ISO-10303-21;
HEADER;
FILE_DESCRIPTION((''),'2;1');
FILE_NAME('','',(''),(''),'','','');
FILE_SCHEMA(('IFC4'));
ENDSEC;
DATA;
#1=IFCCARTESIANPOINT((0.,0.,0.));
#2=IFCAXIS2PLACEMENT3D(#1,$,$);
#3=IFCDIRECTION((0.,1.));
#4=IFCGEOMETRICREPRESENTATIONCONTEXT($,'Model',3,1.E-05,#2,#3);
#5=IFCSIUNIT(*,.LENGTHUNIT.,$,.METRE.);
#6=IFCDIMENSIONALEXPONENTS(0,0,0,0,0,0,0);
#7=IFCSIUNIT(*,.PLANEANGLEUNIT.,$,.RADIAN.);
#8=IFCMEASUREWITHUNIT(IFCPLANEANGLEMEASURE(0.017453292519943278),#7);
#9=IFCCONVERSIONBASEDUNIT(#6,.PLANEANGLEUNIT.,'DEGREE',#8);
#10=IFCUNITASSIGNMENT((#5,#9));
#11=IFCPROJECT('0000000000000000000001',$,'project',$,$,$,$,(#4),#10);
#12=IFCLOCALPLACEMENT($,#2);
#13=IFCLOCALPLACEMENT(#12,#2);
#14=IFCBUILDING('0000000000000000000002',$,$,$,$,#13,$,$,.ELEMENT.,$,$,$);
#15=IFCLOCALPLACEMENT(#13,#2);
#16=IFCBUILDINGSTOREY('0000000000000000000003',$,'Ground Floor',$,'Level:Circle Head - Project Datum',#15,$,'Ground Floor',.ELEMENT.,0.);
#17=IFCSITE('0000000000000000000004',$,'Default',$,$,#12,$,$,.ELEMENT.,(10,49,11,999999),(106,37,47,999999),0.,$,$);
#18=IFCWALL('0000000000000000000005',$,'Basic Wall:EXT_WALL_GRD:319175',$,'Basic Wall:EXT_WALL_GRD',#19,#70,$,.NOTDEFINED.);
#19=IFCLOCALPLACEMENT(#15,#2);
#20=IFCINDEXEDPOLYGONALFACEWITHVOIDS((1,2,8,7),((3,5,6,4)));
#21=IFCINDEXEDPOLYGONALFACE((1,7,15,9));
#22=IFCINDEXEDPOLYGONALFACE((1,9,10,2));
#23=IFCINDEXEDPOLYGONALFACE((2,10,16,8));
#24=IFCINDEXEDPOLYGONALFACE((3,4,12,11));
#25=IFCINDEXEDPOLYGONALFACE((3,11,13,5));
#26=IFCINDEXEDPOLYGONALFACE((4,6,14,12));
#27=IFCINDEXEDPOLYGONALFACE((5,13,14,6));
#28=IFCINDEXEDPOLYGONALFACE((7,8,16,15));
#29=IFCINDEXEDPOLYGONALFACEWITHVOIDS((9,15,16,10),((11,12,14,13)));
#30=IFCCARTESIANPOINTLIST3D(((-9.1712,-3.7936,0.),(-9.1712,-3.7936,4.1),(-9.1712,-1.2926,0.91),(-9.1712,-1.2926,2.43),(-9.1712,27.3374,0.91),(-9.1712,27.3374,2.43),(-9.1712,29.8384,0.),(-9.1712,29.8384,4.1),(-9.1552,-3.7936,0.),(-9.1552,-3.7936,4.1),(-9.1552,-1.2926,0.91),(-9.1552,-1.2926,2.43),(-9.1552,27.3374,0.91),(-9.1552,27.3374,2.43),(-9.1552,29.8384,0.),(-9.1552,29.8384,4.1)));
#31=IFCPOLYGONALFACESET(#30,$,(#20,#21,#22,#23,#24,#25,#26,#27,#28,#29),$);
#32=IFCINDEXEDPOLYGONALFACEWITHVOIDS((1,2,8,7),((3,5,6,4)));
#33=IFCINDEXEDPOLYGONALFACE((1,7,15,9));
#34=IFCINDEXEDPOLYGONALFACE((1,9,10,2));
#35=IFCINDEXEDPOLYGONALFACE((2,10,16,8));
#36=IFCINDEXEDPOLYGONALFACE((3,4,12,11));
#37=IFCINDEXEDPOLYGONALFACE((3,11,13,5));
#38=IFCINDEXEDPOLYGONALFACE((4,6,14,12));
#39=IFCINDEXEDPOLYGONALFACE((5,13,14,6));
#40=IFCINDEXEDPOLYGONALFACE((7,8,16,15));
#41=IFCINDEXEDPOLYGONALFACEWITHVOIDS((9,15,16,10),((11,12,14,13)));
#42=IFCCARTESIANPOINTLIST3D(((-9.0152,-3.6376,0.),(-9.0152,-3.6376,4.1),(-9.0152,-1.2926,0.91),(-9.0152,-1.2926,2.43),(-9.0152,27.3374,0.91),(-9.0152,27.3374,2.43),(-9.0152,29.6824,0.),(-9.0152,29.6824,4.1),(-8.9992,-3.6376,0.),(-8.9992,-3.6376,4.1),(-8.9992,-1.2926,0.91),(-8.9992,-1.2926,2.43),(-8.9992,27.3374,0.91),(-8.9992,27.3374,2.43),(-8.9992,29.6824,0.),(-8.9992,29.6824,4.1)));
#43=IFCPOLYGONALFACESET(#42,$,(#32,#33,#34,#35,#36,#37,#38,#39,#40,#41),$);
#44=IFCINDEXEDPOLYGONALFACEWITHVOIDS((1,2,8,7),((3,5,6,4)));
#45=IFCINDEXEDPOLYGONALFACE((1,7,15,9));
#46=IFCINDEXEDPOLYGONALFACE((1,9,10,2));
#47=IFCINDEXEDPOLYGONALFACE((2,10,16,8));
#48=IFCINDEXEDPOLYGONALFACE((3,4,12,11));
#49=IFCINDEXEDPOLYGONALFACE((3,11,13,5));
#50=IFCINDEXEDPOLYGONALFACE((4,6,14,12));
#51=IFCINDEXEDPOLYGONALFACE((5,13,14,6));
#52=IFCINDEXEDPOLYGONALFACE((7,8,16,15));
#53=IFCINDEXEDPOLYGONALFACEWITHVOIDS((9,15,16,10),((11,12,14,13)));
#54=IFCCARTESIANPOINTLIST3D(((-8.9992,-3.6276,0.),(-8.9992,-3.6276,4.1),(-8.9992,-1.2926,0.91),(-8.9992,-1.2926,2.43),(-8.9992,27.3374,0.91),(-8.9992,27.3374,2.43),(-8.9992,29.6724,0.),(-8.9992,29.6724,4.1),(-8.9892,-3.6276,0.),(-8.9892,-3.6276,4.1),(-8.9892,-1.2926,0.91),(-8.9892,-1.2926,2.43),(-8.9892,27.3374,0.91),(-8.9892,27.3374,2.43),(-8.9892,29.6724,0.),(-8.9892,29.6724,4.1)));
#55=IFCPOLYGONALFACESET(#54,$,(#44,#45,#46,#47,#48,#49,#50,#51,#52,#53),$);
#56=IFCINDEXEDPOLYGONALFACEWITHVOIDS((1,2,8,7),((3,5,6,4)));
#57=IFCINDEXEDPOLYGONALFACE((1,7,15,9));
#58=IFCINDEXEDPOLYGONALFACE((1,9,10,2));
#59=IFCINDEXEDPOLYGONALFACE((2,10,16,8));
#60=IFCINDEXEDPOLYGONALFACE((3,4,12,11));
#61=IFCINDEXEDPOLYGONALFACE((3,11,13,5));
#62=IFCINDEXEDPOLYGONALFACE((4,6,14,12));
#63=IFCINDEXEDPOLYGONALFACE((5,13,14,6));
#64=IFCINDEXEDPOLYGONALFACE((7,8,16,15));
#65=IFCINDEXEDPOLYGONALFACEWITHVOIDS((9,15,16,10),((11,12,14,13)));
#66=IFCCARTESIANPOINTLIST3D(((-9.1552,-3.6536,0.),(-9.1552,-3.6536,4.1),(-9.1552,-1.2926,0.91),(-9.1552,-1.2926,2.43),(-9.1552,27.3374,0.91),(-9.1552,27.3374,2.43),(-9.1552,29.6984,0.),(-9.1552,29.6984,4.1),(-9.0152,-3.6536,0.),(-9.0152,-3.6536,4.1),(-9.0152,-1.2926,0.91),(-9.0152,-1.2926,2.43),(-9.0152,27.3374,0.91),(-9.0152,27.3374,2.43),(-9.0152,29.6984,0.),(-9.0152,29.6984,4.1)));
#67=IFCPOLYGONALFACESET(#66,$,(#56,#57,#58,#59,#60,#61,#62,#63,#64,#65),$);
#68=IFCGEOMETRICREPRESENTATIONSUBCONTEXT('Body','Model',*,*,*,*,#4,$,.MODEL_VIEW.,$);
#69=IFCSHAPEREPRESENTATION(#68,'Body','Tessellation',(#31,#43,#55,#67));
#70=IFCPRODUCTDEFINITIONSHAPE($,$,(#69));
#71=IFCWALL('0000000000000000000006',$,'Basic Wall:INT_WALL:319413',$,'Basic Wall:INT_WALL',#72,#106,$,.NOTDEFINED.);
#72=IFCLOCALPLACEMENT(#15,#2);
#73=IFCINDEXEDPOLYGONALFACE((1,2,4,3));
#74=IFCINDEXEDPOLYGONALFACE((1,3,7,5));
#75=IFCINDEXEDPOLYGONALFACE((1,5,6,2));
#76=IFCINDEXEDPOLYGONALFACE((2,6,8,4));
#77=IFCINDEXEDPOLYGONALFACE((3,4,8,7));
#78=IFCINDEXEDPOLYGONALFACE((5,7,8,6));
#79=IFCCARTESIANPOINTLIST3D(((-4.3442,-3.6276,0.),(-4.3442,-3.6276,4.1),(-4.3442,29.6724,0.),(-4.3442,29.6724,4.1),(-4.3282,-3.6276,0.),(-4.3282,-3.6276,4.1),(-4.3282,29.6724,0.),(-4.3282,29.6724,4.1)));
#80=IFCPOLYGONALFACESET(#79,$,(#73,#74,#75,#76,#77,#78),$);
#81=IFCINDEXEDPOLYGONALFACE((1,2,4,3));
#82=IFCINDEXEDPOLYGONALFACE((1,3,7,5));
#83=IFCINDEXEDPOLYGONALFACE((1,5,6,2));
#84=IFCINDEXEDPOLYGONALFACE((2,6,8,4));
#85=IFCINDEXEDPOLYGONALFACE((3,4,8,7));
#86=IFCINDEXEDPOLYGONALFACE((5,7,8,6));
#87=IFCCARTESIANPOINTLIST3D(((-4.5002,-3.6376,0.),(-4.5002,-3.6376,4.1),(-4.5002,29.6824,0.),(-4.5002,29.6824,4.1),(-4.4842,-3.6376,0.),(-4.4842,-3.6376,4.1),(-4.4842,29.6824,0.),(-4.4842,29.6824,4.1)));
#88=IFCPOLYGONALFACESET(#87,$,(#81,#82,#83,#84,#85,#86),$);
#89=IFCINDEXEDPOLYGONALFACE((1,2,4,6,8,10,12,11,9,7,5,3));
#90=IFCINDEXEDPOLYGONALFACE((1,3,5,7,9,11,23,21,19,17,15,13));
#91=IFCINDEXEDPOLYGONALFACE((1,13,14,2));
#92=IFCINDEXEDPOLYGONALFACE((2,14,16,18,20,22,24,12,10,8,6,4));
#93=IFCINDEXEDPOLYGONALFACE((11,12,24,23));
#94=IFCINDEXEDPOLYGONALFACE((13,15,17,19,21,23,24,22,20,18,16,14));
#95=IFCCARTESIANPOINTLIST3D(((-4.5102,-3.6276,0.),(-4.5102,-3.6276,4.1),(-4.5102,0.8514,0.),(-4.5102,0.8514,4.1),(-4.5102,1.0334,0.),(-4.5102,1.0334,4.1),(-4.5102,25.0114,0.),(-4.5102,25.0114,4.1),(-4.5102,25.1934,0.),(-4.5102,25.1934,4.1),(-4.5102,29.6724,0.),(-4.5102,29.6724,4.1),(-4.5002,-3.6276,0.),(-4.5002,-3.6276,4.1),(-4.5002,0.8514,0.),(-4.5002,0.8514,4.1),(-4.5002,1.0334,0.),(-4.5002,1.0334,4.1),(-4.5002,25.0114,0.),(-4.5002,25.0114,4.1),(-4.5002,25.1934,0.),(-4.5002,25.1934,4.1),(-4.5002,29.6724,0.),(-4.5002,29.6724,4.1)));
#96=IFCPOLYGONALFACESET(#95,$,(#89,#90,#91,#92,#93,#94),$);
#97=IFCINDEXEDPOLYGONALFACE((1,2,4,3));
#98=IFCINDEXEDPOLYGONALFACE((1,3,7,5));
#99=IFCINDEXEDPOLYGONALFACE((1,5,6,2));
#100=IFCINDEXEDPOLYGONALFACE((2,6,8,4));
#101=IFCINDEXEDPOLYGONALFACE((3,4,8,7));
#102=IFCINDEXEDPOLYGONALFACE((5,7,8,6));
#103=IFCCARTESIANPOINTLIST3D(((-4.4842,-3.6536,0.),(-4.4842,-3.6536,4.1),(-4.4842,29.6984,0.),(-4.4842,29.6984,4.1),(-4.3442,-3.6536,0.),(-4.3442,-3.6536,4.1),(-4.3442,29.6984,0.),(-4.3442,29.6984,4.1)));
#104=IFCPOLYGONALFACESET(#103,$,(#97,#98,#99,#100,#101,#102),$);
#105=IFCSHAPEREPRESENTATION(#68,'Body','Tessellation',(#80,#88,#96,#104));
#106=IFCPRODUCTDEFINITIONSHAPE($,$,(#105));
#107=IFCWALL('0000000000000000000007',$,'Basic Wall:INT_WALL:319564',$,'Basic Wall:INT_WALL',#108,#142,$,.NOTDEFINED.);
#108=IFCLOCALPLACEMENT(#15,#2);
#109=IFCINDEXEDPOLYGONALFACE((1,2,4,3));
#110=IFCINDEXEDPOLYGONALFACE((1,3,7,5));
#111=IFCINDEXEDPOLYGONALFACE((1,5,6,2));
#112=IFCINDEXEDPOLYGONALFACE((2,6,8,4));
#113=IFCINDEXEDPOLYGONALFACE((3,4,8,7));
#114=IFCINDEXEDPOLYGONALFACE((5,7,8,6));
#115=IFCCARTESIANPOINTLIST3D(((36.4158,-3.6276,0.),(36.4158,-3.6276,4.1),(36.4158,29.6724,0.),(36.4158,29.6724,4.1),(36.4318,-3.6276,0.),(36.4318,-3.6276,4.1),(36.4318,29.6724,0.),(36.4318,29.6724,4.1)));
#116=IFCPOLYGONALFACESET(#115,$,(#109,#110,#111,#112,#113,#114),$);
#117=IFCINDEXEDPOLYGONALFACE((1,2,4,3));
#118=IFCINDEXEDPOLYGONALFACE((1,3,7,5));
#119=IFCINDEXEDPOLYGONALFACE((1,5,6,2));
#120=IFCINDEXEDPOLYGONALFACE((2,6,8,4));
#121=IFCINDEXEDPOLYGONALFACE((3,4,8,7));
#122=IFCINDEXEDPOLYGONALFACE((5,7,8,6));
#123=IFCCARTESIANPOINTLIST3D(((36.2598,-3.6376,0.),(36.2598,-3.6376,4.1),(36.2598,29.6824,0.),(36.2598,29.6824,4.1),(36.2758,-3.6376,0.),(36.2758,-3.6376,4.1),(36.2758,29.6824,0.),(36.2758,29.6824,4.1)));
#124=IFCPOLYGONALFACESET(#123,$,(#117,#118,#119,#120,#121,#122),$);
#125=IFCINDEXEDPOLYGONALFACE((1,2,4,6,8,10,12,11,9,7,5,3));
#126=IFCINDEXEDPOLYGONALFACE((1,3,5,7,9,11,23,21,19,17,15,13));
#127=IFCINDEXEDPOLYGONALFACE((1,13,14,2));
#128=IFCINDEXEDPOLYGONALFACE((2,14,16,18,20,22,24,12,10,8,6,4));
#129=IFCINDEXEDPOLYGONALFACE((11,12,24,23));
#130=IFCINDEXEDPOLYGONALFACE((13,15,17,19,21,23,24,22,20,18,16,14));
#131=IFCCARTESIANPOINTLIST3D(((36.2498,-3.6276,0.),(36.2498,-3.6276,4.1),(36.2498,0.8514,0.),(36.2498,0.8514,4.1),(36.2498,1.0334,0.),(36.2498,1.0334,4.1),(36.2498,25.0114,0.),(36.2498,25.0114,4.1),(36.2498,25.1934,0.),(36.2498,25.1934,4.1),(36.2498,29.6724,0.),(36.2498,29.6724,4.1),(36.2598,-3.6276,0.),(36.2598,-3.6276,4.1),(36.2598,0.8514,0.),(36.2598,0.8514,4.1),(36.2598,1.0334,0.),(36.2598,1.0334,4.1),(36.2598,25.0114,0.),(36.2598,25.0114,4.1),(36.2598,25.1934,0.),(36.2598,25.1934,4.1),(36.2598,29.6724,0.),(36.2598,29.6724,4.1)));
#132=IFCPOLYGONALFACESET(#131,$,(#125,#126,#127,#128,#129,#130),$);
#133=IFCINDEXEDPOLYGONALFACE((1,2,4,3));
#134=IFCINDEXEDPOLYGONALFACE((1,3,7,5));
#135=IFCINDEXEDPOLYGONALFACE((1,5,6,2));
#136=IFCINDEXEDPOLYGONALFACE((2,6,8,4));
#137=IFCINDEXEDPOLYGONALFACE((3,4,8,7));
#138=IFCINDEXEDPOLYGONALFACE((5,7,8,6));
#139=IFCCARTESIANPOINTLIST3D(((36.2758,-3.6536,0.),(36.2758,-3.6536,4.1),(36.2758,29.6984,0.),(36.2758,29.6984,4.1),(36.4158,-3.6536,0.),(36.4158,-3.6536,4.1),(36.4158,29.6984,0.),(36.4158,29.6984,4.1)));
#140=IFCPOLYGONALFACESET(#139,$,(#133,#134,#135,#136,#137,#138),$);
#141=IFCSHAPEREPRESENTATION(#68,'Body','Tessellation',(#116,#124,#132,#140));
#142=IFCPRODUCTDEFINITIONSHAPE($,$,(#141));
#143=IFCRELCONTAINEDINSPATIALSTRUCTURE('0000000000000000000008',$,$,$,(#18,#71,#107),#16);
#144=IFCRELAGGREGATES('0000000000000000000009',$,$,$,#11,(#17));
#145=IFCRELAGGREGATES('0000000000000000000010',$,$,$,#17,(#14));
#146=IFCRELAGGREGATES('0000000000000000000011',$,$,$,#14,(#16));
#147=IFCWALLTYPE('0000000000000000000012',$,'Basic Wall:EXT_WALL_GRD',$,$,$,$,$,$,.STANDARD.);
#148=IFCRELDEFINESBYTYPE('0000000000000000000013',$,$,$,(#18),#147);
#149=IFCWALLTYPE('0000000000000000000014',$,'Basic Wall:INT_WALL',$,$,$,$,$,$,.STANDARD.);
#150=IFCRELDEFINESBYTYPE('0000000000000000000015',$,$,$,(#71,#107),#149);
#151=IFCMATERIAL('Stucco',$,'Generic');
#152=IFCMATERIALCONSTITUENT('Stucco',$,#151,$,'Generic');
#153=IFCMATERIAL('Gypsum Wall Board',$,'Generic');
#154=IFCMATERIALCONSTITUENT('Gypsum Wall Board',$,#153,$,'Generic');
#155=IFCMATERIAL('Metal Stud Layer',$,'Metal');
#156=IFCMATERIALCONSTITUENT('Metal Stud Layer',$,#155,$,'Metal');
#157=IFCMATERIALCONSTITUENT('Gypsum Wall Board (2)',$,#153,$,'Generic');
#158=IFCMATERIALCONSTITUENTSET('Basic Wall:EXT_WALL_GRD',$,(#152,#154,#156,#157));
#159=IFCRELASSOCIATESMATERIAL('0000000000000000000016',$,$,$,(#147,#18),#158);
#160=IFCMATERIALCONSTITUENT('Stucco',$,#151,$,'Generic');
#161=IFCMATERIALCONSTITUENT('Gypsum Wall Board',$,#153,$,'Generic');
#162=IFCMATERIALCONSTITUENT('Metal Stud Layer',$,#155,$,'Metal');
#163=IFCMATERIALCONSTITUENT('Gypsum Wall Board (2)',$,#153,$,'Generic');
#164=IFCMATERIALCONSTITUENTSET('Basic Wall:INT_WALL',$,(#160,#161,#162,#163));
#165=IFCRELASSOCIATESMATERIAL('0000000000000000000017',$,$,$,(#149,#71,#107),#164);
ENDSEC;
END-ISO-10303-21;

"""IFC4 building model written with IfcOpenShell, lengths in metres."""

from ifc_helpers import new_model, entity, si_unit, converted_unit, direction, frame, origin, place, context, subcontext, project, spatial, indexed_curve, outline, extrude, material, constituent, constituent_set, type_object, element, save


model = new_model("IFC4")

# Units and contexts
model_context = context("Model", 3, precision=1e-05, world=origin(), true_north=direction((0.0, 1.0)))
body_context = subcontext(model_context, "Body", "Model", "MODEL_VIEW")
ifc_project = project(units=[si_unit("LENGTHUNIT", "METRE"), converted_unit("PLANEANGLEUNIT", "DEGREE", entity("IfcPlaneAngleMeasure", 0.017453292519943278), si_unit("PLANEANGLEUNIT", "RADIAN"), dimensions=[0, 0, 0, 0, 0, 0, 0])], contexts=[model_context])

# Site, building, storey
site_placement = place(None, origin())
site = spatial("IfcSite", under=ifc_project, at=site_placement, Name="Default", CompositionType="ELEMENT", RefLatitude=(10, 49, 11, 999999), RefLongitude=(106, 37, 47, 999999), RefElevation=0.0)
building_placement = place(site_placement, origin())
building = spatial("IfcBuilding", under=site, at=building_placement, CompositionType="ELEMENT")
storey_placement = place(building_placement, origin())
storey = spatial("IfcBuildingStorey", under=building, at=storey_placement, Name="Ground Floor", ObjectType="Level:Circle Head - Project Datum", LongName="Ground Floor", CompositionType="ELEMENT", Elevation=0.0)

# Wall, opening
ifc_material_1 = material(Name="Stucco", Category="Generic")
ifc_constituent_1 = constituent(ifc_material_1, Name="Stucco", Category="Generic")
ifc_material_2 = material(Name="Gypsum Wall Board", Category="Generic")
ifc_constituent_2 = constituent(ifc_material_2, Name="Gypsum Wall Board", Category="Generic")
ifc_material_3 = material(Name="Metal Stud Layer", Category="Metal")
ifc_constituent_3 = constituent(ifc_material_3, Name="Metal Stud Layer", Category="Metal")
ifc_constituent_4 = constituent(ifc_material_2, Name="Gypsum Wall Board (2)", Category="Generic")
ifc_constituent_set_1 = constituent_set(constituents=[ifc_constituent_1, ifc_constituent_2, ifc_constituent_3, ifc_constituent_4], Name="Basic Wall:EXT_WALL_GRD")
wall_type_1 = type_object("IfcWallType", Name="Basic Wall:EXT_WALL_GRD", PredefinedType="STANDARD", material=ifc_constituent_set_1)
wall_1_placement = place(storey_placement, frame((-9.0802, 29.6724, 0.0), z_axis=(0.0, 0.0, 1.0), x_axis=(0.0, -1.0, 0.0)))
wall_1 = element("IfcWall", 1, at=wall_1_placement, inside=storey, type_object=wall_type_1, material=ifc_constituent_set_1, Name="Basic Wall:EXT_WALL_GRD:319175", ObjectType="Basic Wall:EXT_WALL_GRD", PredefinedType="NOTDEFINED", context=body_context, shape_type="SweptSolid", body=[
    extrude(outline(indexed_curve([(-2.05, -16.816), (2.05, -16.816), (2.05, 16.816), (-2.05, 16.816), (-2.05, -16.816)], self_intersect=False), holes=[indexed_curve([(0.38, 14.315), (0.38, -14.315), (-1.14, -14.315), (-1.14, 14.315), (0.38, 14.315)], self_intersect=False)]), frame((16.65, -0.091, 2.05), z_axis=(0.0, 1.0, 0.0), x_axis=(0.0, 0.0, 1.0)), (0.0, 0.0, 1.0), 0.016),
    extrude(outline(indexed_curve([(-2.05, -16.66), (2.05, -16.66), (2.05, 16.66), (-2.05, 16.66), (-2.05, -16.66)], self_intersect=False), holes=[indexed_curve([(0.38, 14.315), (0.38, -14.315), (-1.14, -14.315), (-1.14, 14.315), (0.38, 14.315)], self_intersect=False)]), frame((16.65, 0.065, 2.05), z_axis=(0.0, 1.0, 0.0), x_axis=(0.0, 0.0, 1.0)), (0.0, 0.0, 1.0), 0.016),
    extrude(outline(indexed_curve([(-2.05, -16.65), (2.05, -16.65), (2.05, 16.65), (-2.05, 16.65), (-2.05, -16.65)], self_intersect=False), holes=[indexed_curve([(0.38, 14.315), (0.38, -14.315), (-1.14, -14.315), (-1.14, 14.315), (0.38, 14.315)], self_intersect=False)]), frame((16.65, 0.081, 2.05), z_axis=(0.0, 1.0, 0.0), x_axis=(0.0, 0.0, 1.0)), (0.0, 0.0, 1.0), 0.01),
    extrude(outline(indexed_curve([(-2.05, -16.676), (2.05, -16.676), (2.05, 16.676), (-2.05, 16.676), (-2.05, -16.676)], self_intersect=False), holes=[indexed_curve([(0.38, 14.315), (0.38, -14.315), (-1.14, -14.315), (-1.14, 14.315), (0.38, 14.315)], self_intersect=False)]), frame((16.65, -0.075, 2.05), z_axis=(0.0, 1.0, 0.0), x_axis=(0.0, 0.0, 1.0)), (0.0, 0.0, 1.0), 0.14),
])
opening_1_placement = place(wall_1_placement, frame((30.965, 0.091, 0.91)))
element("IfcOpeningElement", 2, at=opening_1_placement, cuts=wall_1, PredefinedType="OPENING", context=body_context, shape_type="SweptSolid", body=[
    extrude(outline(indexed_curve([(1.52, 0.0), (1.52, 28.63), (0.0, 28.63), (0.0, 0.0), (1.52, 0.0)], self_intersect=False)), frame((0.0, 0.0, 0.0), z_axis=(0.0, -1.0, 0.0), x_axis=(0.0, 0.0, 1.0)), (0.0, 0.0, 1.0), 0.182),
])

# Walls
ifc_constituent_5 = constituent(ifc_material_1, Name="Stucco", Category="Generic")
ifc_constituent_6 = constituent(ifc_material_2, Name="Gypsum Wall Board", Category="Generic")
ifc_constituent_7 = constituent(ifc_material_3, Name="Metal Stud Layer", Category="Metal")
ifc_constituent_8 = constituent(ifc_material_2, Name="Gypsum Wall Board (2)", Category="Generic")
ifc_constituent_set_2 = constituent_set(constituents=[ifc_constituent_5, ifc_constituent_6, ifc_constituent_7, ifc_constituent_8], Name="Basic Wall:INT_WALL")
wall_type_2 = type_object("IfcWallType", Name="Basic Wall:INT_WALL", PredefinedType="STANDARD", material=ifc_constituent_set_2)
wall_2_placement = place(storey_placement, frame((-4.4192, -3.6276, 0.0), z_axis=(0.0, 0.0, 1.0), x_axis=(0.0, 1.0, 0.0)))
element("IfcWall", 3, at=wall_2_placement, inside=storey, type_object=wall_type_2, material=ifc_constituent_set_2, Name="Basic Wall:INT_WALL:319413", ObjectType="Basic Wall:INT_WALL", PredefinedType="NOTDEFINED", context=body_context, shape_type="SweptSolid", body=[
    extrude(outline(indexed_curve([(-2.05, -16.65), (2.05, -16.65), (2.05, 16.65), (-2.05, 16.65), (-2.05, -16.65)], self_intersect=False)), frame((16.65, -0.075, 2.05), z_axis=(0.0, -1.0, 0.0), x_axis=(0.0, 0.0, 1.0)), (0.0, 0.0, 1.0), 0.016),
    extrude(outline(indexed_curve([(-2.05, -16.66), (2.05, -16.66), (2.05, 16.66), (-2.05, 16.66), (-2.05, -16.66)], self_intersect=False)), frame((16.65, 0.081, 2.05), z_axis=(0.0, -1.0, 0.0), x_axis=(0.0, 0.0, 1.0)), (0.0, 0.0, 1.0), 0.016),
    extrude(outline(indexed_curve([(-16.65, -2.05), (-12.171, -2.05), (-11.989, -2.05), (11.989, -2.05), (12.171, -2.05), (16.65, -2.05), (16.65, 2.05), (12.171, 2.05), (11.989, 2.05), (-11.989, 2.05), (-12.171, 2.05), (-16.65, 2.05), (-16.65, -2.05)], self_intersect=False)), frame((16.65, 0.091, 2.05), z_axis=(0.0, -1.0, 0.0), x_axis=(1.0, 0.0, 0.0)), (0.0, 0.0, 1.0), 0.01),
    extrude(outline(indexed_curve([(-2.05, -16.676), (2.05, -16.676), (2.05, 16.676), (-2.05, 16.676), (-2.05, -16.676)], self_intersect=False)), frame((16.65, 0.065, 2.05), z_axis=(0.0, -1.0, 0.0), x_axis=(0.0, 0.0, 1.0)), (0.0, 0.0, 1.0), 0.14),
])
wall_3_placement = place(storey_placement, frame((36.3408, -3.6276, 0.0), z_axis=(0.0, 0.0, 1.0), x_axis=(0.0, 1.0, 0.0)))
element("IfcWall", 4, at=wall_3_placement, inside=storey, type_object=wall_type_2, material=ifc_constituent_set_2, Name="Basic Wall:INT_WALL:319564", ObjectType="Basic Wall:INT_WALL", PredefinedType="NOTDEFINED", context=body_context, shape_type="SweptSolid", body=[
    extrude(outline(indexed_curve([(-2.05, -16.65), (2.05, -16.65), (2.05, 16.65), (-2.05, 16.65), (-2.05, -16.65)], self_intersect=False)), frame((16.65, -0.075, 2.05), z_axis=(0.0, -1.0, 0.0), x_axis=(0.0, 0.0, 1.0)), (0.0, 0.0, 1.0), 0.016),
    extrude(outline(indexed_curve([(-2.05, -16.66), (2.05, -16.66), (2.05, 16.66), (-2.05, 16.66), (-2.05, -16.66)], self_intersect=False)), frame((16.65, 0.081, 2.05), z_axis=(0.0, -1.0, 0.0), x_axis=(0.0, 0.0, 1.0)), (0.0, 0.0, 1.0), 0.016),
    extrude(outline(indexed_curve([(-16.65, -2.05), (-12.171, -2.05), (-11.989, -2.05), (11.989, -2.05), (12.171, -2.05), (16.65, -2.05), (16.65, 2.05), (12.171, 2.05), (11.989, 2.05), (-11.989, 2.05), (-12.171, 2.05), (-16.65, 2.05), (-16.65, -2.05)], self_intersect=False)), frame((16.65, 0.091, 2.05), z_axis=(0.0, -1.0, 0.0), x_axis=(1.0, 0.0, 0.0)), (0.0, 0.0, 1.0), 0.01),
    extrude(outline(indexed_curve([(-2.05, -16.676), (2.05, -16.676), (2.05, 16.676), (-2.05, 16.676), (-2.05, -16.676)], self_intersect=False)), frame((16.65, 0.065, 2.05), z_axis=(0.0, -1.0, 0.0), x_axis=(0.0, 0.0, 1.0)), (0.0, 0.0, 1.0), 0.14),
])

save(model, "model.ifc")
